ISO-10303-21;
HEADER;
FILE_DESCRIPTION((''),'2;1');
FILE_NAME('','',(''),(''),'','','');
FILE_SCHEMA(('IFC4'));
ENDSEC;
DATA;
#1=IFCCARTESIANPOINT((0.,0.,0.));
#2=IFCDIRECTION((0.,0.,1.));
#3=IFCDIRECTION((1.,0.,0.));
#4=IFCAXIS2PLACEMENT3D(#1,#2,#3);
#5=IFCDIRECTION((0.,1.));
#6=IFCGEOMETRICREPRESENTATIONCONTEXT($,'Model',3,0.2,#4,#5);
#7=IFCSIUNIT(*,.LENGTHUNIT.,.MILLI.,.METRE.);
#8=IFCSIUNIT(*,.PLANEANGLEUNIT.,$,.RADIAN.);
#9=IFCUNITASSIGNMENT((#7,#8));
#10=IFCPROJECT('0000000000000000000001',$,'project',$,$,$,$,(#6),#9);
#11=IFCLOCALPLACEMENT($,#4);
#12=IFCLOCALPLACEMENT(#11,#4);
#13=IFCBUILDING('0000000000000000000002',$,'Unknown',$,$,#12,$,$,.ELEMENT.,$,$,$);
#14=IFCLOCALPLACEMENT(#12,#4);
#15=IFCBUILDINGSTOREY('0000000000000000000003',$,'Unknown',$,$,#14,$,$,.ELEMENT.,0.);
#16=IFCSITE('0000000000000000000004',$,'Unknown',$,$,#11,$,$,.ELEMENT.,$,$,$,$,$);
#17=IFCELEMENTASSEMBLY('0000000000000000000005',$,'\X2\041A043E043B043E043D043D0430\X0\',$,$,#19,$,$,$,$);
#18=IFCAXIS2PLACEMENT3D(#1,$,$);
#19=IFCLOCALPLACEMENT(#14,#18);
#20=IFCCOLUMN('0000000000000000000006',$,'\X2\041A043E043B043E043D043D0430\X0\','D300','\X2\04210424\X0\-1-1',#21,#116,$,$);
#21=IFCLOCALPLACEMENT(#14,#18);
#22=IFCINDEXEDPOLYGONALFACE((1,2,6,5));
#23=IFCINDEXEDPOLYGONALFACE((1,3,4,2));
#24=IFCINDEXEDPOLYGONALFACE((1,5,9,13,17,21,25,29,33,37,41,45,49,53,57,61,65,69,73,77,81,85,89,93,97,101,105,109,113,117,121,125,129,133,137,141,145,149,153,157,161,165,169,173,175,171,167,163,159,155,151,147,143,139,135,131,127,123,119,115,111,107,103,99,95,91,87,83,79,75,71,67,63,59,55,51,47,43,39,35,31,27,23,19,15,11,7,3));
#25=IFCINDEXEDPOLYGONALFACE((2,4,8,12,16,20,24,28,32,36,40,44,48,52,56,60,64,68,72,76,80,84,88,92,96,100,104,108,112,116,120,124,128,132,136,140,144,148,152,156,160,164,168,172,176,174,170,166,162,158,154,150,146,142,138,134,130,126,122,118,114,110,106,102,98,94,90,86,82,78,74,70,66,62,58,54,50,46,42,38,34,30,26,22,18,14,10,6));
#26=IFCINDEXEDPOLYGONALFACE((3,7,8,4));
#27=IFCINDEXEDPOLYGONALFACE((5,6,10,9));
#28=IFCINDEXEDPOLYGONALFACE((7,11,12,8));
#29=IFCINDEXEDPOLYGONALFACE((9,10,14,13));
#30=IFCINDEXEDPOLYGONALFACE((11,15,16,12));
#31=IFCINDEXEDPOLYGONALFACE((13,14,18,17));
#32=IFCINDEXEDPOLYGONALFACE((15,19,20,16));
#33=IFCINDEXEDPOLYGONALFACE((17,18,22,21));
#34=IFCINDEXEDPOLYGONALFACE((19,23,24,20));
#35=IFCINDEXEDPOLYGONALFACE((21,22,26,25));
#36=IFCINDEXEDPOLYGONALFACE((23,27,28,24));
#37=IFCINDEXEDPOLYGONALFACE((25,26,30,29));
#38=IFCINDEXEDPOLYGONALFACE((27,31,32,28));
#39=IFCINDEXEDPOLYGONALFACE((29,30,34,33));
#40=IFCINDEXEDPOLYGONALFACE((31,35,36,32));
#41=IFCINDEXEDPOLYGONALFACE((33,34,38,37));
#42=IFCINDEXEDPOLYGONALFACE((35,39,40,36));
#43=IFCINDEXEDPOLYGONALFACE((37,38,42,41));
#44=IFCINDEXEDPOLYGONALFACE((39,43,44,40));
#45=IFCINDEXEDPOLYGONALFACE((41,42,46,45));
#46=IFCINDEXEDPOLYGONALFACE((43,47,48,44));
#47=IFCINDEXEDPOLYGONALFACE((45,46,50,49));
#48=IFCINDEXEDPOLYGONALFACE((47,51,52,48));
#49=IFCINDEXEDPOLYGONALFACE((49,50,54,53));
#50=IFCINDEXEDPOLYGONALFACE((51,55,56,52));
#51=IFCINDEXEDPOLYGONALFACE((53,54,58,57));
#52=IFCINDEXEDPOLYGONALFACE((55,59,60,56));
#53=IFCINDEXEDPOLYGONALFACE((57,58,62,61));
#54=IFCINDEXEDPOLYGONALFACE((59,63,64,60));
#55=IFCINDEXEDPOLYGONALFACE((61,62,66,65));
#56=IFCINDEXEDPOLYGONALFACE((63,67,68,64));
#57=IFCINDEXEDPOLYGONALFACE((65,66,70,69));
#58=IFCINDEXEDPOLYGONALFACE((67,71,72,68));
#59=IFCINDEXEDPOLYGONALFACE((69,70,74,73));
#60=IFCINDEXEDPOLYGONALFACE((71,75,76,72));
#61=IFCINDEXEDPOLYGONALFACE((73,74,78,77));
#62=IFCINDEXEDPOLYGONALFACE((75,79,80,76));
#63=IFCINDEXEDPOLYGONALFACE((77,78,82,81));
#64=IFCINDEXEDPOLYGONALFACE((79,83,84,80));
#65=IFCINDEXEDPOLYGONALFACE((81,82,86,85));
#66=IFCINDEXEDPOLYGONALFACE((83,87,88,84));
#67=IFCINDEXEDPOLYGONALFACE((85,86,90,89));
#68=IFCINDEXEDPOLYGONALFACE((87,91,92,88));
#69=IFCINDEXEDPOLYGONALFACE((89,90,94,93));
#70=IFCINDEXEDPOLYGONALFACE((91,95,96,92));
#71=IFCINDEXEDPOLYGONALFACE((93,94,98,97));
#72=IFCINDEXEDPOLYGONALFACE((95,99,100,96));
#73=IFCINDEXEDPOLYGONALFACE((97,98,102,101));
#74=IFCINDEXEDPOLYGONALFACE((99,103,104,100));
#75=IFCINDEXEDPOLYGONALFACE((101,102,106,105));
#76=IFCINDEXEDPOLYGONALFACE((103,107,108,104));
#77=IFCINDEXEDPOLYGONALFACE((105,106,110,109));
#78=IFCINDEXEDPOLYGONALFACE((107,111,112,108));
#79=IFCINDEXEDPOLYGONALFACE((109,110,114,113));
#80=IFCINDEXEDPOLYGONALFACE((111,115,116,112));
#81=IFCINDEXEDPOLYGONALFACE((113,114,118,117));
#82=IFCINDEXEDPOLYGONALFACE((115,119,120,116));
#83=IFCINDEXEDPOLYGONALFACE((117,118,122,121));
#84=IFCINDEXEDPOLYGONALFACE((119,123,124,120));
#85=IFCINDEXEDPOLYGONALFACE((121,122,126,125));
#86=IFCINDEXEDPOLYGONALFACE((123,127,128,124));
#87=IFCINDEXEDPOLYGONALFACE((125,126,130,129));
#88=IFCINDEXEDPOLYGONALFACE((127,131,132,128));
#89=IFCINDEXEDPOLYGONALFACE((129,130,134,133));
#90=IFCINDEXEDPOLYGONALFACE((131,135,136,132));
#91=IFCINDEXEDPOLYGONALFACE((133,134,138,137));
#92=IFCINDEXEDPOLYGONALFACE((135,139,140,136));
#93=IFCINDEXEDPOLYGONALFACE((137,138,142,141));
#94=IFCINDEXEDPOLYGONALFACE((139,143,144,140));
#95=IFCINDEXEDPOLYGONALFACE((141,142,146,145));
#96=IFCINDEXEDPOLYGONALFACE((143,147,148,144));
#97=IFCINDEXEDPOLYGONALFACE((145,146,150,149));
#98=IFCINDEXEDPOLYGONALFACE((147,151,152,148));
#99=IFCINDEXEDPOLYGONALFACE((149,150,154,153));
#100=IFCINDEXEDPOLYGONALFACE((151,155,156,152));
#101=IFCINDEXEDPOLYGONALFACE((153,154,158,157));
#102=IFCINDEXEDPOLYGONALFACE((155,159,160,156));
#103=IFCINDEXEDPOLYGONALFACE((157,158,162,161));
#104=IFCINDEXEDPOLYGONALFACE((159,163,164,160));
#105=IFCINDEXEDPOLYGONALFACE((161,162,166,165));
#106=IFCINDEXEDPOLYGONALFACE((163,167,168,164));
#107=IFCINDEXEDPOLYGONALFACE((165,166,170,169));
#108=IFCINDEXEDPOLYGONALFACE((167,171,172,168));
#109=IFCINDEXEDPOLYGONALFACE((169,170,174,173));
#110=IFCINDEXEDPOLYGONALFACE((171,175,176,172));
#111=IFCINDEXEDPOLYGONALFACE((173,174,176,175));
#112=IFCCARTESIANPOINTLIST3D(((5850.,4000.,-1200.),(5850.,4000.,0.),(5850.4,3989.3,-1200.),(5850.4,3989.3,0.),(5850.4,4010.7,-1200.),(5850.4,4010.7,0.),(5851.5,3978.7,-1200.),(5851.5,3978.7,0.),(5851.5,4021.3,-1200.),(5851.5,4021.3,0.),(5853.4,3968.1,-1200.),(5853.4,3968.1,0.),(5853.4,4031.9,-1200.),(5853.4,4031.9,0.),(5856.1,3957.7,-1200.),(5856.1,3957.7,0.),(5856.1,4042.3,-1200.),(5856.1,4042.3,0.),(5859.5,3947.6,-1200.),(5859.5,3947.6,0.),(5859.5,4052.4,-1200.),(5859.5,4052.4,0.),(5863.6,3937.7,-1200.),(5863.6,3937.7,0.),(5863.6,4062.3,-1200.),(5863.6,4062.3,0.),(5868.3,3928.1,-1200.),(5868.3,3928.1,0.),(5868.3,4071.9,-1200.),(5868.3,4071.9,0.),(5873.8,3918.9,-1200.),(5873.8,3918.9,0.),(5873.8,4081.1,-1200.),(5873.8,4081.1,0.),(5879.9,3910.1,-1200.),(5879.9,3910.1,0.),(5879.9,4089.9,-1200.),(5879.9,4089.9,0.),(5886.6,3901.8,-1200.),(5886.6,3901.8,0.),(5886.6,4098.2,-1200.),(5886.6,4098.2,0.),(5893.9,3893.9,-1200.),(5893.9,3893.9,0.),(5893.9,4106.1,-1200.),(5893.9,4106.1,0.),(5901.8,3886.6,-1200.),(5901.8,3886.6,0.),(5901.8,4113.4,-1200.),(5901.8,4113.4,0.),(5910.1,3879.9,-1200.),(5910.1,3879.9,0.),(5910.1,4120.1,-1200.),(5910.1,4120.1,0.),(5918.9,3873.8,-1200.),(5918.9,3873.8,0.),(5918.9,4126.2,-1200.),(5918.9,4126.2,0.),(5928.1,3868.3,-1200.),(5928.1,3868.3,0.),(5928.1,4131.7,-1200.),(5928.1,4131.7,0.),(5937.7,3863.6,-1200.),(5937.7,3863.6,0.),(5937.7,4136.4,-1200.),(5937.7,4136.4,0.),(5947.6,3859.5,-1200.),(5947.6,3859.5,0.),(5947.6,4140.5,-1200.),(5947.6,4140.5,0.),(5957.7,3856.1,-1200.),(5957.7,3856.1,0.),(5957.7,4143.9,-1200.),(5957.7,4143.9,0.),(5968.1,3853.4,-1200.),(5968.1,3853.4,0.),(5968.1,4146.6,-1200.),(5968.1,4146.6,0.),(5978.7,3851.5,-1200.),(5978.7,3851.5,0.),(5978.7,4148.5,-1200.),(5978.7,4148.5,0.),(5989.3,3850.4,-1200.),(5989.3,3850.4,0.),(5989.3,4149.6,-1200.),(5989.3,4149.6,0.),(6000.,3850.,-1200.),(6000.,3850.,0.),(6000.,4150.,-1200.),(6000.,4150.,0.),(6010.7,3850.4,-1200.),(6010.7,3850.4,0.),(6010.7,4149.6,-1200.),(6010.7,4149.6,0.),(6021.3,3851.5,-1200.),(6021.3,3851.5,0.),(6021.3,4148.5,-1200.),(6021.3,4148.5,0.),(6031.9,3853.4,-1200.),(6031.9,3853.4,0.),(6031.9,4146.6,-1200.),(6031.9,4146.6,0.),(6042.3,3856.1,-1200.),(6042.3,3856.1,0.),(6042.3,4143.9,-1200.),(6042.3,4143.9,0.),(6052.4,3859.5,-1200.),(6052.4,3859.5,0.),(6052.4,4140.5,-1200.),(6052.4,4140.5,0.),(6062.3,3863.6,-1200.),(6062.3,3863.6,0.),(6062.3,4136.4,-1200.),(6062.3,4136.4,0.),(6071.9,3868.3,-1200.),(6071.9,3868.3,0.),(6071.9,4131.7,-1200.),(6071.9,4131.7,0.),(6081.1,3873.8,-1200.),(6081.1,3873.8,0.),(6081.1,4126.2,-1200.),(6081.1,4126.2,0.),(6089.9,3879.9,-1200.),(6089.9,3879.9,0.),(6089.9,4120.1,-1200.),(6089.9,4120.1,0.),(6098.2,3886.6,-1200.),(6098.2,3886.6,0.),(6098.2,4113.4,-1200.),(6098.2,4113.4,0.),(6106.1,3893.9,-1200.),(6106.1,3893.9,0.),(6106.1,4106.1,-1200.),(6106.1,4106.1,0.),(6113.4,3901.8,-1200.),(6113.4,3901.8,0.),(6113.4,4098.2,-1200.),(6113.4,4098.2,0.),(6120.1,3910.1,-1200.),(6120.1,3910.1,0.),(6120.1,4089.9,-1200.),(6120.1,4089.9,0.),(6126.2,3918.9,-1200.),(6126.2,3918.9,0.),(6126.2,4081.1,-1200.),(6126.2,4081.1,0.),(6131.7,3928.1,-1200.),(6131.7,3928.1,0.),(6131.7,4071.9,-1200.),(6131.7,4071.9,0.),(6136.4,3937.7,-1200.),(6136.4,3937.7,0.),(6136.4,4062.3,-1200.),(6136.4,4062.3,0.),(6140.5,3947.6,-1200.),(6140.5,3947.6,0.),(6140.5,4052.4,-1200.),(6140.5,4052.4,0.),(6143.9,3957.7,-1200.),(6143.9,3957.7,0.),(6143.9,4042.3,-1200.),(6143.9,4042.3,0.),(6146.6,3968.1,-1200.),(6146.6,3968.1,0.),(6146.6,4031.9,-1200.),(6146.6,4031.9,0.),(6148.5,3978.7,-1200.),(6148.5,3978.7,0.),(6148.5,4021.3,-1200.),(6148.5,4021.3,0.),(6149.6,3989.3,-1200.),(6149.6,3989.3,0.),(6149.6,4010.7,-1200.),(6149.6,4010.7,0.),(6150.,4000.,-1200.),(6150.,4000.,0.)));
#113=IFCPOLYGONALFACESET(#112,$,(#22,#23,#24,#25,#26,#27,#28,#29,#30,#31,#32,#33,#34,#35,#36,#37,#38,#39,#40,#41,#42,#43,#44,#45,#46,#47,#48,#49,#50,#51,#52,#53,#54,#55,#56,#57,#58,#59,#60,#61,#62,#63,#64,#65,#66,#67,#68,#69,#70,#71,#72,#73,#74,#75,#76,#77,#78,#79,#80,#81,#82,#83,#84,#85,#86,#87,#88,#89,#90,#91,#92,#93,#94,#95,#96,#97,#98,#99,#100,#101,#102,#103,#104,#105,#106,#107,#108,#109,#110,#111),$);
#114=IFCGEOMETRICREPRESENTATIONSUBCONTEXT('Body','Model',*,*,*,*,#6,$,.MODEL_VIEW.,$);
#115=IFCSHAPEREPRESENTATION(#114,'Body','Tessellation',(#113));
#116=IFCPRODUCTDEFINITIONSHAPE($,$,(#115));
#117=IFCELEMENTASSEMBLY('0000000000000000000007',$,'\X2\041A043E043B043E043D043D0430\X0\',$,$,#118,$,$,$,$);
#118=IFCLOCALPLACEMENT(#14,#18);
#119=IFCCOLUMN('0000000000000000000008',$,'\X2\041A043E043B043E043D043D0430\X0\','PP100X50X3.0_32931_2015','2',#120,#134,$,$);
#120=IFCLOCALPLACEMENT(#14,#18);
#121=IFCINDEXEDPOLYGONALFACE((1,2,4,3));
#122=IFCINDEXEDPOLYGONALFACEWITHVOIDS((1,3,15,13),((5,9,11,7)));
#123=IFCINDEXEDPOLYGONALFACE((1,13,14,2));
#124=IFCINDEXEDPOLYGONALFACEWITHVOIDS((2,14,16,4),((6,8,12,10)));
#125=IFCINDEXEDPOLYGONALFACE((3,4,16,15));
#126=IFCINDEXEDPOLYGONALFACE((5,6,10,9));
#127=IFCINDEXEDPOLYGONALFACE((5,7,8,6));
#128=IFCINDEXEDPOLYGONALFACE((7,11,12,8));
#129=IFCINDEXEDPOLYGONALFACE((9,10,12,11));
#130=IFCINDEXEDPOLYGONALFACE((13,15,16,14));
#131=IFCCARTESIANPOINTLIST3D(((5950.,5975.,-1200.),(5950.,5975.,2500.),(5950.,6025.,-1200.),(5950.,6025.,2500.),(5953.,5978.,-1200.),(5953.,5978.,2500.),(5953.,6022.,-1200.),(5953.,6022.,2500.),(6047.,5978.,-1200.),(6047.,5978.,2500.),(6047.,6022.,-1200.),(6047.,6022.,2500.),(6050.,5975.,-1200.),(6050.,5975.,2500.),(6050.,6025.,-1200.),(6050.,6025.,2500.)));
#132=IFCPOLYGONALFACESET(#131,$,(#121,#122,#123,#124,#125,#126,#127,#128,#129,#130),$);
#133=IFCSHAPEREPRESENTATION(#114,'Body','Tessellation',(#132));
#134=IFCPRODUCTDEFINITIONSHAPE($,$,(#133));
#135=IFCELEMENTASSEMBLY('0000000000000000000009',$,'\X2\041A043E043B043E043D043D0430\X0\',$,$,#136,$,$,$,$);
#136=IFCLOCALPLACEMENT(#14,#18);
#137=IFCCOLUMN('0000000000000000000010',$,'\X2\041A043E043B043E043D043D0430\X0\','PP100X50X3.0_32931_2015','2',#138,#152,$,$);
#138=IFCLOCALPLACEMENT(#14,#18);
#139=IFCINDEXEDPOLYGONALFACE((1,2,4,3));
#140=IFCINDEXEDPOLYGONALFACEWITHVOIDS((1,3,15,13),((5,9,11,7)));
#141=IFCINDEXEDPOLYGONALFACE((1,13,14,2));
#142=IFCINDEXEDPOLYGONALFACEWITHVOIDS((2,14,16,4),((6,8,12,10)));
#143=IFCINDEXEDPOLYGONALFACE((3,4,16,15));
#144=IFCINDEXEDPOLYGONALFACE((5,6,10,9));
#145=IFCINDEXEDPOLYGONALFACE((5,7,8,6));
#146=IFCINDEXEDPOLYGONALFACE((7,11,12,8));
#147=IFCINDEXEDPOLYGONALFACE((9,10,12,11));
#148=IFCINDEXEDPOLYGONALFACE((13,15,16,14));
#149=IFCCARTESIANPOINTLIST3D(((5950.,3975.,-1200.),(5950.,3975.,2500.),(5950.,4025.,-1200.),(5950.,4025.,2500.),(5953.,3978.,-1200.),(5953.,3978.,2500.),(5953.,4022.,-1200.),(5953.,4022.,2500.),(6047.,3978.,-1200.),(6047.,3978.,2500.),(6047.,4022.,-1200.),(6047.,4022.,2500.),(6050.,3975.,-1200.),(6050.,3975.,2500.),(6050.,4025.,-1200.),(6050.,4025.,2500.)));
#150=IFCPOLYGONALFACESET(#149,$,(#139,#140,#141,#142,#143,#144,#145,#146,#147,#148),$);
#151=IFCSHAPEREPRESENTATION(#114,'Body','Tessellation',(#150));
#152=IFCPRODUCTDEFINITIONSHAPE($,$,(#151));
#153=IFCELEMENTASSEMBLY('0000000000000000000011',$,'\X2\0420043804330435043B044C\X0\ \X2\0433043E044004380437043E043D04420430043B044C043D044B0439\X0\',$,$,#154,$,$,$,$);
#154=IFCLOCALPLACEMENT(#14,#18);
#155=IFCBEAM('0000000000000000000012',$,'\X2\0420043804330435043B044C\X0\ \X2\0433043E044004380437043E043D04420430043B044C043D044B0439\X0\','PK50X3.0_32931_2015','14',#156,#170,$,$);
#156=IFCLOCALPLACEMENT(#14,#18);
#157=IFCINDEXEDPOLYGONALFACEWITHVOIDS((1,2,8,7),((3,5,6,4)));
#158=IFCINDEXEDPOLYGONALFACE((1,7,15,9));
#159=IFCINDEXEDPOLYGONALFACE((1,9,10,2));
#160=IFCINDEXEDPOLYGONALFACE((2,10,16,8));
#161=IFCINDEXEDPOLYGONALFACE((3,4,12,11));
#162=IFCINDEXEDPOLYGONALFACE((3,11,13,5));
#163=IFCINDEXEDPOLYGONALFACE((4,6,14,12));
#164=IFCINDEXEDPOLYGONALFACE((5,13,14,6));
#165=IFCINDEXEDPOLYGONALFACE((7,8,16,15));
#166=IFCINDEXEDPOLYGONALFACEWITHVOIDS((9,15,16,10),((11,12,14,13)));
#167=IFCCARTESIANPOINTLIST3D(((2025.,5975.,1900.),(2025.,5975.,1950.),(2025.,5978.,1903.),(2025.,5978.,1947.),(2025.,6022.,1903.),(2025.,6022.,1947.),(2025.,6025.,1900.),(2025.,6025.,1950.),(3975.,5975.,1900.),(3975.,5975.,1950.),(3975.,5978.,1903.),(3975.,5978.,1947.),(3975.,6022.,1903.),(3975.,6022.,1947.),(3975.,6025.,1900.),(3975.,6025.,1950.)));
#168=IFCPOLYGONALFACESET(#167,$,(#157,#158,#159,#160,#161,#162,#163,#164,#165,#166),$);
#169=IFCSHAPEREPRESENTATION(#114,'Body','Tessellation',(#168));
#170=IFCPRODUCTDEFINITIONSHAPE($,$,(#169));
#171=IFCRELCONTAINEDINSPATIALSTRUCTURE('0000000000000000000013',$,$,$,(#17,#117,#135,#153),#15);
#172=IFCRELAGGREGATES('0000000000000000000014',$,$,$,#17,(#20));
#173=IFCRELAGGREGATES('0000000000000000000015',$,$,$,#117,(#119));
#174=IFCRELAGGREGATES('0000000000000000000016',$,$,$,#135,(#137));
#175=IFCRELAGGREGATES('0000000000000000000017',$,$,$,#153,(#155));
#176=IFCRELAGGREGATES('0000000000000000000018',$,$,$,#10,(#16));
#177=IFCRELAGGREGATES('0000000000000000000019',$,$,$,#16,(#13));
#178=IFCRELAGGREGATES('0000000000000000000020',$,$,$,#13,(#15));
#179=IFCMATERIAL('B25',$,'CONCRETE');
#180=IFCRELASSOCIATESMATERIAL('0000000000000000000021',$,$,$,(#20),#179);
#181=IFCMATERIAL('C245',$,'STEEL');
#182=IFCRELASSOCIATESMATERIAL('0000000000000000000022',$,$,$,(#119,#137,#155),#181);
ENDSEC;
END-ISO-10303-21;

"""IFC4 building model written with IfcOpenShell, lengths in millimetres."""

from ifc_helpers import new_model, si_unit, direction, frame, origin_with_axes, place, context, subcontext, project, spatial, line, indexed_curve, outline, extrude, material, element, aggregate, save


model = new_model("IFC4")

# Units and contexts
model_context = context("Model", 3, precision=0.2, world=origin_with_axes(), true_north=direction((0.0, 1.0)))
body_context = subcontext(model_context, "Body", "Model", "MODEL_VIEW")
ifc_project = project(units=[si_unit("LENGTHUNIT", "METRE", prefix="MILLI"), si_unit("PLANEANGLEUNIT", "RADIAN")], contexts=[model_context])

# Site, building, storey
site_placement = place(None, origin_with_axes())
site = spatial("IfcSite", under=ifc_project, at=site_placement, Name="Unknown", CompositionType="ELEMENT")
building_placement = place(site_placement, origin_with_axes())
building = spatial("IfcBuilding", under=site, at=building_placement, Name="Unknown", CompositionType="ELEMENT")
storey_placement = place(building_placement, origin_with_axes())
storey = spatial("IfcBuildingStorey", under=building, at=storey_placement, Name="Unknown", CompositionType="ELEMENT", Elevation=0.0)

# Element assemblies, columns
ifc_material_1 = material(Name="B25", Category="CONCRETE")
assembly_1_placement = place(storey_placement, frame((6000.0, 4000.0, -1200.0), z_axis=(-1.0, 0.0, 0.0), x_axis=(0.0, 0.0, 1.0)))
assembly_1 = element("IfcElementAssembly", 1, at=assembly_1_placement, inside=storey, Name="Колонна")
column_1_placement = place(assembly_1_placement, origin_with_axes())
column_1 = element("IfcColumn", 2, at=column_1_placement, material=ifc_material_1, Name="Колонна", Description="D300", ObjectType="СФ-1-1", context=body_context, shape_type="SolidModel", body=[
    extrude(outline(indexed_curve([(150.0, 0.0), (149.6, 10.7), (148.5, 21.3), (146.6, 31.9), (143.9, 42.3), (140.5, 52.4), (136.4, 62.3), (131.7, 71.9), (126.2, 81.1), (120.1, 89.9), (113.4, 98.2), (106.1, 106.1), (98.2, 113.4), (89.9, 120.1), (81.1, 126.2), (71.9, 131.7), (62.3, 136.4), (52.4, 140.5), (42.3, 143.9), (31.9, 146.6), (21.3, 148.5), (10.7, 149.6), (0.0, 150.0), (-10.7, 149.6), (-21.3, 148.5), (-31.9, 146.6), (-42.3, 143.9), (-52.4, 140.5), (-62.3, 136.4), (-71.9, 131.7), (-81.1, 126.2), (-89.9, 120.1), (-98.2, 113.4), (-106.1, 106.1), (-113.4, 98.2), (-120.1, 89.9), (-126.2, 81.1), (-131.7, 71.9), (-136.4, 62.3), (-140.5, 52.4), (-143.9, 42.3), (-146.6, 31.9), (-148.5, 21.3), (-149.6, 10.7), (-150.0, 0.0), (-149.6, -10.7), (-148.5, -21.3), (-146.6, -31.9), (-143.9, -42.3), (-140.5, -52.4), (-136.4, -62.3), (-131.7, -71.9), (-126.2, -81.1), (-120.1, -89.9), (-113.4, -98.2), (-106.1, -106.1), (-98.2, -113.4), (-89.9, -120.1), (-81.1, -126.2), (-71.9, -131.7), (-62.3, -136.4), (-52.4, -140.5), (-42.3, -143.9), (-31.9, -146.6), (-21.3, -148.5), (-10.7, -149.6), (0.0, -150.0), (10.7, -149.6), (21.3, -148.5), (31.9, -146.6), (42.3, -143.9), (52.4, -140.5), (62.3, -136.4), (71.9, -131.7), (81.1, -126.2), (89.9, -120.1), (98.2, -113.4), (106.1, -106.1), (113.4, -98.2), (120.1, -89.9), (126.2, -81.1), (131.7, -71.9), (136.4, -62.3), (140.5, -52.4), (143.9, -42.3), (146.6, -31.9), (148.5, -21.3), (149.6, -10.7)], segments=[line(1, 2, 3, 4, 5, 6, 7, 8, 9, 10, 11, 12, 13, 14, 15, 16, 17, 18, 19, 20, 21, 22, 23, 24, 25, 26, 27, 28, 29, 30, 31, 32, 33, 34, 35, 36, 37, 38, 39, 40, 41, 42, 43, 44, 45, 46, 47, 48, 49, 50, 51, 52, 53, 54, 55, 56, 57, 58, 59, 60, 61, 62, 63, 64, 65, 66, 67, 68, 69, 70, 71, 72, 73, 74, 75, 76, 77, 78, 79, 80, 81, 82, 83, 84, 85, 86, 87, 88, 1)])), frame((0.0, 0.0, 0.0), z_axis=(-1.0, 0.0, 0.0), x_axis=(0.0, 0.0, 1.0)), (0.0, 0.0, -1.0), 1200.0),
])
aggregate(assembly_1, [column_1])
assembly_2_placement = place(storey_placement, frame((6000.0, 6000.0, -1200.0), z_axis=(0.0, -1.0, 0.0), x_axis=(0.0, 0.0, 1.0)))
assembly_2 = element("IfcElementAssembly", 3, at=assembly_2_placement, inside=storey, Name="Колонна")
ifc_material_2 = material(Name="C245", Category="STEEL")
column_2_placement = place(assembly_2_placement, origin_with_axes())
column_2 = element("IfcColumn", 4, at=column_2_placement, material=ifc_material_2, Name="Колонна", Description="PP100X50X3.0_32931_2015", ObjectType="2", context=body_context, shape_type="SolidModel", body=[
    extrude(outline(indexed_curve([(-25.0, -50.0), (25.0, -50.0), (25.0, 50.0), (-25.0, 50.0)], segments=[line(1, 2, 3, 4, 1)]), holes=[indexed_curve([(-22.0, -47.0), (-22.0, 47.0), (22.0, 47.0), (22.0, -47.0)], segments=[line(1, 2, 3, 4, 1)])]), frame((0.0, 0.0, 0.0), z_axis=(-1.0, 0.0, 0.0), x_axis=(0.0, 0.0, 1.0)), (0.0, 0.0, -1.0), 3700.0),
])
aggregate(assembly_2, [column_2])
assembly_3_placement = place(storey_placement, frame((6000.0, 4000.0, -1200.0), z_axis=(0.0, -1.0, 0.0), x_axis=(0.0, 0.0, 1.0)))
assembly_3 = element("IfcElementAssembly", 5, at=assembly_3_placement, inside=storey, Name="Колонна")
column_3_placement = place(assembly_3_placement, origin_with_axes())
column_3 = element("IfcColumn", 6, at=column_3_placement, material=ifc_material_2, Name="Колонна", Description="PP100X50X3.0_32931_2015", ObjectType="2", context=body_context, shape_type="SolidModel", body=[
    extrude(outline(indexed_curve([(-25.0, -50.0), (25.0, -50.0), (25.0, 50.0), (-25.0, 50.0)], segments=[line(1, 2, 3, 4, 1)]), holes=[indexed_curve([(-22.0, -47.0), (-22.0, 47.0), (22.0, 47.0), (22.0, -47.0)], segments=[line(1, 2, 3, 4, 1)])]), frame((0.0, 0.0, 0.0), z_axis=(-1.0, 0.0, 0.0), x_axis=(0.0, 0.0, 1.0)), (0.0, 0.0, -1.0), 3700.0),
])
aggregate(assembly_3, [column_3])

# Element assembly, beam
assembly_4_placement = place(storey_placement, frame((3975.0, 6000.0, 1925.0), z_axis=(0.0, 1.0, 0.0), x_axis=(-1.0, 0.0, 0.0)))
assembly_4 = element("IfcElementAssembly", 7, at=assembly_4_placement, inside=storey, Name="Ригель горизонтальный")
beam_1_placement = place(assembly_4_placement, origin_with_axes())
beam_1 = element("IfcBeam", 8, at=beam_1_placement, material=ifc_material_2, Name="Ригель горизонтальный", Description="PK50X3.0_32931_2015", ObjectType="14", context=body_context, shape_type="SolidModel", body=[
    extrude(outline(indexed_curve([(-25.0, -25.0), (25.0, -25.0), (25.0, 25.0), (-25.0, 25.0)], segments=[line(1, 2, 3, 4, 1)]), holes=[indexed_curve([(-22.0, -22.0), (-22.0, 22.0), (22.0, 22.0), (22.0, -22.0)], segments=[line(1, 2, 3, 4, 1)])]), frame((0.0, 0.0, 0.0), z_axis=(-1.0, 0.0, 0.0), x_axis=(0.0, 0.0, 1.0)), (0.0, 0.0, -1.0), 1950.0),
])
aggregate(assembly_4, [beam_1])

save(model, "model.ifc")
